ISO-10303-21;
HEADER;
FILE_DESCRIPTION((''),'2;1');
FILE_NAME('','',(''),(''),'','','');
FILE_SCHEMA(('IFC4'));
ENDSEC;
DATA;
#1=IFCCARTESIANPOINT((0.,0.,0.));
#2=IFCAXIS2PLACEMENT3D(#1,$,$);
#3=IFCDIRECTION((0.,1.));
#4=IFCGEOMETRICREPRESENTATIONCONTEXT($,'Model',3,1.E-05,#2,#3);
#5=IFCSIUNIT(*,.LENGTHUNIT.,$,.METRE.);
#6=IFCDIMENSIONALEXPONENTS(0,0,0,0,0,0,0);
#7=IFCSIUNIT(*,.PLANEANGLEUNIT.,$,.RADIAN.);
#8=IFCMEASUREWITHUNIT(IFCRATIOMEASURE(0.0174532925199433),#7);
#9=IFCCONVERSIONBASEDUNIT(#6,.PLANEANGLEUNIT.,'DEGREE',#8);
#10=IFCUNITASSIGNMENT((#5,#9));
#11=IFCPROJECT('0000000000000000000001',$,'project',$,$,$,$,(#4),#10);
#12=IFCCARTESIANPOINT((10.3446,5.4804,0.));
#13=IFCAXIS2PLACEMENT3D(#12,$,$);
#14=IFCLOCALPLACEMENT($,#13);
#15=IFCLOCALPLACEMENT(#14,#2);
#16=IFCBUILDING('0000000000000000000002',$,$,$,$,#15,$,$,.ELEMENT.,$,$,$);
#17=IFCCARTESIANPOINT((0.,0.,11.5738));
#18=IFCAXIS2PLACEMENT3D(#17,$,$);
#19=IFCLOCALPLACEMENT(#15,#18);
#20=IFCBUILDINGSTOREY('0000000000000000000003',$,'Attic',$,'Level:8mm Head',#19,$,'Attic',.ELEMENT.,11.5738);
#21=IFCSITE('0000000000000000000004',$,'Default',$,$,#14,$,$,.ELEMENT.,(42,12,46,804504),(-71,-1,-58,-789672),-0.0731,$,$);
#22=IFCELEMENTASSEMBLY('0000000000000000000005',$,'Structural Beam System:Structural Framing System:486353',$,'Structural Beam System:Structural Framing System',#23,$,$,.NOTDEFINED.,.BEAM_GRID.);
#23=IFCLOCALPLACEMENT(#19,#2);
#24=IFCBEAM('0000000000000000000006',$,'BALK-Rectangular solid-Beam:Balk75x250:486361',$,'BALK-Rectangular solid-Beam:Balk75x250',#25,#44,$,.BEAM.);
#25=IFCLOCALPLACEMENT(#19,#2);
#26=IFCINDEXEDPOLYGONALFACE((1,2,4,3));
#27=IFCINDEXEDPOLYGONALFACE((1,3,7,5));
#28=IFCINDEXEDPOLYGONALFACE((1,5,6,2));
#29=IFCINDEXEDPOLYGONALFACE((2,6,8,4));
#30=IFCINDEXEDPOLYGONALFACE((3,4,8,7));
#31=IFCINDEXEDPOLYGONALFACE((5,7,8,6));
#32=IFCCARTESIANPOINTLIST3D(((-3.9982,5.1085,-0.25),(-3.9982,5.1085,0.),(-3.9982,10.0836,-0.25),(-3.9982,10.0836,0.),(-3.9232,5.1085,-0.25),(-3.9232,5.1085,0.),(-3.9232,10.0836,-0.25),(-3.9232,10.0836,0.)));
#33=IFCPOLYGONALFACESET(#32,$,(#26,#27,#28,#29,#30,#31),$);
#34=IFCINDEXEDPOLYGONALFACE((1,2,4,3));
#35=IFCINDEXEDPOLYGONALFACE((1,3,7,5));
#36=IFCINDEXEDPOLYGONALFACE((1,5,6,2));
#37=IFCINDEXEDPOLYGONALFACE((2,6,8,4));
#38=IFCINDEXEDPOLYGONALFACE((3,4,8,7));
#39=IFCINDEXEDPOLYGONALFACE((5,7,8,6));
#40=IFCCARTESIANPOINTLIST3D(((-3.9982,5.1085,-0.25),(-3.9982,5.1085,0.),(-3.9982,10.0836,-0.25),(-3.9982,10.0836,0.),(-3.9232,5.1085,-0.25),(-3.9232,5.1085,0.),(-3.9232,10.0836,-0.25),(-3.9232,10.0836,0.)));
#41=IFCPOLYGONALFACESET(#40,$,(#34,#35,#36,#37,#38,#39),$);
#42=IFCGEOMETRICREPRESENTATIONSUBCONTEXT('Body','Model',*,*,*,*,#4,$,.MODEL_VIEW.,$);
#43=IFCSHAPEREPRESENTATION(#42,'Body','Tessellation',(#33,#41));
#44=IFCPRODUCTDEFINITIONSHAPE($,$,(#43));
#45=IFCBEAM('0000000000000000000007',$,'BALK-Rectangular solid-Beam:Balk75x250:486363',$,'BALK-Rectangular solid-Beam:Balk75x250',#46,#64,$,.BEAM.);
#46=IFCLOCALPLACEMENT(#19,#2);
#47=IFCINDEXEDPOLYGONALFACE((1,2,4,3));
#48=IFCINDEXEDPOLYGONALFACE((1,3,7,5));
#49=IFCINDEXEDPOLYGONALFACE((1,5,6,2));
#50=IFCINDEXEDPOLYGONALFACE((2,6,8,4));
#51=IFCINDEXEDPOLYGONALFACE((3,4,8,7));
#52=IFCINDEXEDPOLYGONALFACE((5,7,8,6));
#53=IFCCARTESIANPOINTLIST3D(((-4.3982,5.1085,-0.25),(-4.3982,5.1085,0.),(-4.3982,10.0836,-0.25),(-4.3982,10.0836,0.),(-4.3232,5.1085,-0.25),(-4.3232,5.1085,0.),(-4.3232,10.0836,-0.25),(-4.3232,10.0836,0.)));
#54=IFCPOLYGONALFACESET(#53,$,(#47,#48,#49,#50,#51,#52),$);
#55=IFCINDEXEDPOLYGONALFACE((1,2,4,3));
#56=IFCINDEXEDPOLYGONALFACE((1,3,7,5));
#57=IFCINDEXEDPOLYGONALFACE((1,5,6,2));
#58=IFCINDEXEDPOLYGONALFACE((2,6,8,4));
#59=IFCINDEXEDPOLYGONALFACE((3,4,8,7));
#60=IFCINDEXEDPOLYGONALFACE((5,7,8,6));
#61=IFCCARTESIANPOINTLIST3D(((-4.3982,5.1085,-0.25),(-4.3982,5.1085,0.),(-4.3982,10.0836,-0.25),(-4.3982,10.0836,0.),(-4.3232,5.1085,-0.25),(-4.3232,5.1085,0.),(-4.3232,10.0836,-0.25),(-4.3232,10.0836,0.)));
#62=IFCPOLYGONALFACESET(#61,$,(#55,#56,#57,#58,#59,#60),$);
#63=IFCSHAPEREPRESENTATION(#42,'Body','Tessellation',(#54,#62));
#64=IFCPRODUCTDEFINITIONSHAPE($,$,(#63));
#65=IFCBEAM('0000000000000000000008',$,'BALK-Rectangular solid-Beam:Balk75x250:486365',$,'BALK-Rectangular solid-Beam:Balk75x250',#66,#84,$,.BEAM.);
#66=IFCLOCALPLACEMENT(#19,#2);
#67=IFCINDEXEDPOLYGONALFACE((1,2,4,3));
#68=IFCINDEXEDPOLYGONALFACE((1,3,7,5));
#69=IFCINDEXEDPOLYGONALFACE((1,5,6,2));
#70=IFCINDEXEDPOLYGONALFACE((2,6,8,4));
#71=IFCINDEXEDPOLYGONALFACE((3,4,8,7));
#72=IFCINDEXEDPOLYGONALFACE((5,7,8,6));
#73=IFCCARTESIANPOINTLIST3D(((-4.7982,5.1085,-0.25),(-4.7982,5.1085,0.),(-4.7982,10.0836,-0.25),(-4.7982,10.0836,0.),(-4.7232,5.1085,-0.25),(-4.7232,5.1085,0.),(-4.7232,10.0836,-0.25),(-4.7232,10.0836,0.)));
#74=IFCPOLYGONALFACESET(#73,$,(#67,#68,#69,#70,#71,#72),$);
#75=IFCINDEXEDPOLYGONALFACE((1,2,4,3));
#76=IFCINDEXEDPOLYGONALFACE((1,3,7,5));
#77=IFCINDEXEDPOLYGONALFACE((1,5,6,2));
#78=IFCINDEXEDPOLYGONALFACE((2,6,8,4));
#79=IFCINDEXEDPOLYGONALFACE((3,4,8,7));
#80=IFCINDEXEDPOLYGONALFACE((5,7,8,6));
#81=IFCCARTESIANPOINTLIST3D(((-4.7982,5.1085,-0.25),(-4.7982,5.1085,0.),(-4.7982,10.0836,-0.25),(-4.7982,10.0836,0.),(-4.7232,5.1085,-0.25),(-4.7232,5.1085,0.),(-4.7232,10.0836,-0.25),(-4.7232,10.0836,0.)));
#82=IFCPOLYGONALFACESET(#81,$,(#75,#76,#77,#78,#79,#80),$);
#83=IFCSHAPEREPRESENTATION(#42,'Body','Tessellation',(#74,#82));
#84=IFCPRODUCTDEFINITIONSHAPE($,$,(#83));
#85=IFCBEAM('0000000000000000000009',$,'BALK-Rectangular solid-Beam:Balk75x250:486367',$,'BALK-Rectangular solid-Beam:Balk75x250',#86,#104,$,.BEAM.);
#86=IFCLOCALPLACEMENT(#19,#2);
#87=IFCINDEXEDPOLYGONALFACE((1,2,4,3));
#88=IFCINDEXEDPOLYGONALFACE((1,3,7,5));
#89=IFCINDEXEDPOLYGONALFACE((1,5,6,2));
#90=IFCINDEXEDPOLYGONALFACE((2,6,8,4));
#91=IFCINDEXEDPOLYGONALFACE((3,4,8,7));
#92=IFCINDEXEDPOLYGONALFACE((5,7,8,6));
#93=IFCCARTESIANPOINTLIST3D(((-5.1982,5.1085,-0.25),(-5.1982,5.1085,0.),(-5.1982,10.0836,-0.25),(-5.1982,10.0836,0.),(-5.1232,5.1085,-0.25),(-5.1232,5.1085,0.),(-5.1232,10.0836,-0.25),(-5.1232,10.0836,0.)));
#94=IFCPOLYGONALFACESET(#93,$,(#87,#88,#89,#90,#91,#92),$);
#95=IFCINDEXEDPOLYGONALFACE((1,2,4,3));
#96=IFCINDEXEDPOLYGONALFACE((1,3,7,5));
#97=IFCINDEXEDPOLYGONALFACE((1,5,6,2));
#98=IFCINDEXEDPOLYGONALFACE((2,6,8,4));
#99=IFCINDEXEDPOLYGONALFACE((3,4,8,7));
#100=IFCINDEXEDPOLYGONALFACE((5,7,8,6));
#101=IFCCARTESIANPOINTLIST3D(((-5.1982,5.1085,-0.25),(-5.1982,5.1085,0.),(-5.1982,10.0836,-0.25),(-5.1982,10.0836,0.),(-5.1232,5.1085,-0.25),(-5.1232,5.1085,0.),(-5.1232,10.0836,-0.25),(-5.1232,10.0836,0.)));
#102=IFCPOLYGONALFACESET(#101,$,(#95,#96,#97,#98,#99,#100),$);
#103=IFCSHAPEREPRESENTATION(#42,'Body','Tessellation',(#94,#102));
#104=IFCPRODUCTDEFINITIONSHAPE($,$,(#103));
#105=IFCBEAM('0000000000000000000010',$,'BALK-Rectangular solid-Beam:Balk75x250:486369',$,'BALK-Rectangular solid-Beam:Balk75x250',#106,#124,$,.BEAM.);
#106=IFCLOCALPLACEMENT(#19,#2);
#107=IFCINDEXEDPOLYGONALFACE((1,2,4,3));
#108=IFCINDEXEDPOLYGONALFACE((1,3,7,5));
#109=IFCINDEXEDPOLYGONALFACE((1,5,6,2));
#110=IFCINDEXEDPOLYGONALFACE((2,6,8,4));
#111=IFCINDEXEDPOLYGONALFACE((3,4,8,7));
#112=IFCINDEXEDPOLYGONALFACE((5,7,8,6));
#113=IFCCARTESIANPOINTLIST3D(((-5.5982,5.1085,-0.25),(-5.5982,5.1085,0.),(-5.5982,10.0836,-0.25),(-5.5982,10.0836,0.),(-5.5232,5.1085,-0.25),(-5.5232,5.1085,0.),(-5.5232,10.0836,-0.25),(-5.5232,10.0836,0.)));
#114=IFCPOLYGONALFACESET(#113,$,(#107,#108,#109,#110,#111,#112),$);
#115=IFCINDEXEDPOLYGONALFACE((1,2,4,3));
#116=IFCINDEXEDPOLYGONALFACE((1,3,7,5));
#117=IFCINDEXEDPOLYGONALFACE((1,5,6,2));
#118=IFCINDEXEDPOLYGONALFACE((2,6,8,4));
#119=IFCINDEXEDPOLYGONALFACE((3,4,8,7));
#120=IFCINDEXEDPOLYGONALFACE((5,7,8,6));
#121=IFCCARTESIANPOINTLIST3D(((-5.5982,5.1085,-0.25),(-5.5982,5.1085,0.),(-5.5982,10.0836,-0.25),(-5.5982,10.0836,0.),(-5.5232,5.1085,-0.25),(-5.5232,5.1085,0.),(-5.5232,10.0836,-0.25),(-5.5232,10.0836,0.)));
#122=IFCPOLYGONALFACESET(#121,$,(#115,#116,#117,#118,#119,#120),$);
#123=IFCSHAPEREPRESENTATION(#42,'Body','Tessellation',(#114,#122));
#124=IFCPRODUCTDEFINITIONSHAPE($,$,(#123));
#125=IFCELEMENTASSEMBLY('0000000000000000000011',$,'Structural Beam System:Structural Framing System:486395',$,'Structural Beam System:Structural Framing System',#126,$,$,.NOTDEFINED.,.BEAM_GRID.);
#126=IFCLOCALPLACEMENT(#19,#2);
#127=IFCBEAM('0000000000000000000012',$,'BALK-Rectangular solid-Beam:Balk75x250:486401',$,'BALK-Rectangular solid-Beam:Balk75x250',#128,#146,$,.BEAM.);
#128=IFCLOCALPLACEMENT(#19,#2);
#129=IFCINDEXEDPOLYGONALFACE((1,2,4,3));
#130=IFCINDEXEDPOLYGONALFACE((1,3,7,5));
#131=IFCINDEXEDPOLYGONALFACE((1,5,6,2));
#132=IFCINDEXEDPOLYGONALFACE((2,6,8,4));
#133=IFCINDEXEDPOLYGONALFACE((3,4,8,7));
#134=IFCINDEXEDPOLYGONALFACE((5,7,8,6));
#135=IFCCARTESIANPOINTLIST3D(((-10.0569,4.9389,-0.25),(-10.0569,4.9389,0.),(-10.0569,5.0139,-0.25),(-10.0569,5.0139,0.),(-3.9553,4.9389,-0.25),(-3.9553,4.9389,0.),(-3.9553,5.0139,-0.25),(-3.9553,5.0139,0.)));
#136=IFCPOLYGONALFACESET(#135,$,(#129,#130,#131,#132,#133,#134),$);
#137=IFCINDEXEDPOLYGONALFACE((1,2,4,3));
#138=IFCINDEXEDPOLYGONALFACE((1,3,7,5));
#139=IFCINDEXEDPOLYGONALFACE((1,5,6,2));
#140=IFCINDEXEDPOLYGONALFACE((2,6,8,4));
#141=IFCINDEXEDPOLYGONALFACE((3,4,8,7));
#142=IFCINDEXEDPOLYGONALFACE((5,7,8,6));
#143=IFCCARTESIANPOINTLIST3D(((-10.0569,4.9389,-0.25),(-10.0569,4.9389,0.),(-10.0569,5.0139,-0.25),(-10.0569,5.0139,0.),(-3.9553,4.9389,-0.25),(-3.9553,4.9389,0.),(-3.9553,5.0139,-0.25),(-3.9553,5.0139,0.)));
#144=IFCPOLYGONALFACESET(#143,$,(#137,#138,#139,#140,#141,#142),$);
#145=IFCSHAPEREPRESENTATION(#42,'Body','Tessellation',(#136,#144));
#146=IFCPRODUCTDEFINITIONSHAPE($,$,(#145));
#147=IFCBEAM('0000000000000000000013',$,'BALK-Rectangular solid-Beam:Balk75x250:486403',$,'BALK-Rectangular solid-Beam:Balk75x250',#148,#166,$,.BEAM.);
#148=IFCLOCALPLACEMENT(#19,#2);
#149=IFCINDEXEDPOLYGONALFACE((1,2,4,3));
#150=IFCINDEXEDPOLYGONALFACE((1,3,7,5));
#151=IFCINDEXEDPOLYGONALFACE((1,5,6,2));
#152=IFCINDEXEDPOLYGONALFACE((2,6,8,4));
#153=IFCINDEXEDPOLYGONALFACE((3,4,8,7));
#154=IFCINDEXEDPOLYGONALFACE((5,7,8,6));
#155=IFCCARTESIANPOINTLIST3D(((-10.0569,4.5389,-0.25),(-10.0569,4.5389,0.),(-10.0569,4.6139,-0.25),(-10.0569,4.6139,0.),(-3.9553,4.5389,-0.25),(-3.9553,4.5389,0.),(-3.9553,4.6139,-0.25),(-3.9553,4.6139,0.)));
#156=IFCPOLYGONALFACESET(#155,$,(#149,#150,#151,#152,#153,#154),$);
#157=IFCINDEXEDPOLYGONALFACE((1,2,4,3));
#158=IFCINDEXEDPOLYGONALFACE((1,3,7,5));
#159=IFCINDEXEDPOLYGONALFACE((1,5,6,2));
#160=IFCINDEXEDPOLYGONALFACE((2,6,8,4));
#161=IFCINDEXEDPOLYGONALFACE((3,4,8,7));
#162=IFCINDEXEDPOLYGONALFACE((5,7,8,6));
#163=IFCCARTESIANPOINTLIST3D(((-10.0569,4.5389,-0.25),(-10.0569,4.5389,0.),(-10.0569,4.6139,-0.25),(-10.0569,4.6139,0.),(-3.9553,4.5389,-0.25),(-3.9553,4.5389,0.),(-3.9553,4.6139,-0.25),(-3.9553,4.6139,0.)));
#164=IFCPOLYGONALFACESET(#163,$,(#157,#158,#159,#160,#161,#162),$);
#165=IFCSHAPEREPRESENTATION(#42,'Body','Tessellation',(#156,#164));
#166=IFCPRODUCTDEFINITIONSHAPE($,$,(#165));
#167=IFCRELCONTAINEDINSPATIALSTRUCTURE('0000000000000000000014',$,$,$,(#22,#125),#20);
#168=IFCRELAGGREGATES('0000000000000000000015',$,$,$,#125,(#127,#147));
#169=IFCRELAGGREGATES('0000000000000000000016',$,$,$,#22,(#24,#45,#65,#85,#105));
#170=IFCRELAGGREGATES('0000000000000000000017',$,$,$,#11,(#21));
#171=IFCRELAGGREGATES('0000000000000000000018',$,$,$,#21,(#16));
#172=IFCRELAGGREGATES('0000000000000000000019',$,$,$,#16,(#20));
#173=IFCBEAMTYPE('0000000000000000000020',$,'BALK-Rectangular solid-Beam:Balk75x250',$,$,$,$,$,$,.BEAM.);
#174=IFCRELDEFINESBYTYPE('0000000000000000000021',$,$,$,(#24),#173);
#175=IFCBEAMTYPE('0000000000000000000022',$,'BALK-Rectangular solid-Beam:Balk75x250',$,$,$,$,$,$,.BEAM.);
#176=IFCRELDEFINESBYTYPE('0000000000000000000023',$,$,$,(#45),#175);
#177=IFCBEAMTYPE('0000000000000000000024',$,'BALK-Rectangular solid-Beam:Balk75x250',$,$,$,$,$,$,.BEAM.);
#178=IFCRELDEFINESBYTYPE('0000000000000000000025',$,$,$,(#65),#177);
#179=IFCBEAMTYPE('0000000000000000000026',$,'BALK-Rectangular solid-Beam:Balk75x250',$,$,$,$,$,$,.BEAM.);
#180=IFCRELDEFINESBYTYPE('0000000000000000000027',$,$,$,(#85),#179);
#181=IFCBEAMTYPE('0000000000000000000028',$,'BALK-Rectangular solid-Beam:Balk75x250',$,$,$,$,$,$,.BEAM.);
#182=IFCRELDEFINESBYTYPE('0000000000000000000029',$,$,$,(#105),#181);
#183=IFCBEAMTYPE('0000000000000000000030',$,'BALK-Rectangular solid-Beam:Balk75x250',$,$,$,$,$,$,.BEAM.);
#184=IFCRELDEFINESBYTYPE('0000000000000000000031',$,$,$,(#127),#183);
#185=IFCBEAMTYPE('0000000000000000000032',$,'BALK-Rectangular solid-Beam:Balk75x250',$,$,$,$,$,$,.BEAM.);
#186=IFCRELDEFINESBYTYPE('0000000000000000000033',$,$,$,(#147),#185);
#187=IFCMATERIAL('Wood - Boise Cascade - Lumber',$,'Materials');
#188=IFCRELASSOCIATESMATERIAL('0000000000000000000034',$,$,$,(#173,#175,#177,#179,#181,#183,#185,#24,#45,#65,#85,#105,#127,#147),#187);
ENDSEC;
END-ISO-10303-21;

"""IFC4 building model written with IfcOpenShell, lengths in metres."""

from ifc_helpers import new_model, entity, si_unit, converted_unit, direction, frame, frame_2d, origin, place, context, subcontext, project, spatial, rectangle, extrude, source, transform, mapped, material, material_profile, profile_set, profile_usage, type_object, type_shapes, element, aggregate, save


model = new_model("IFC4")

# Units and contexts
model_context = context("Model", 3, precision=1e-05, world=origin(), true_north=direction((0.0, 1.0)))
body_context = subcontext(model_context, "Body", "Model", "MODEL_VIEW")
ifc_project = project(units=[si_unit("LENGTHUNIT", "METRE"), converted_unit("PLANEANGLEUNIT", "DEGREE", entity("IfcRatioMeasure", 0.0174532925199433), si_unit("PLANEANGLEUNIT", "RADIAN"), dimensions=[0, 0, 0, 0, 0, 0, 0])], contexts=[model_context])

# Site, building, storey
site_placement = place(None, frame((10.3446, 5.4804, 0.0)))
site = spatial("IfcSite", under=ifc_project, at=site_placement, Name="Default", CompositionType="ELEMENT", RefLatitude=(42, 12, 46, 804504), RefLongitude=(-71, -1, -58, -789672), RefElevation=-0.0731)
building_placement = place(site_placement, origin())
building = spatial("IfcBuilding", under=site, at=building_placement, CompositionType="ELEMENT")
storey_placement = place(building_placement, frame((0.0, 0.0, 11.5738)))
storey = spatial("IfcBuildingStorey", under=building, at=storey_placement, Name="Attic", ObjectType="Level:8mm Head", LongName="Attic", CompositionType="ELEMENT", Elevation=11.5738)

# Element assemblies, beams
assembly_1_placement = place(storey_placement, origin())
assembly_1 = element("IfcElementAssembly", 1, at=assembly_1_placement, inside=storey, Name="Structural Beam System:Structural Framing System:486353", ObjectType="Structural Beam System:Structural Framing System", AssemblyPlace="NOTDEFINED", PredefinedType="BEAM_GRID")
ifc_material = material(Name="Wood - Boise Cascade - Lumber", Category="Materials")
ifc_material_profile = material_profile(ifc_material, rectangle(XDim=0.25, YDim=0.075, at=frame_2d((0.0, 0.0), x_axis=(1.0, 0.0))), Name="Balk75x250")
ifc_profile_set = profile_set([ifc_material_profile], Name="Balk75x250")
ifc_profile_usage_1 = profile_usage(ifc_profile_set, cardinal=8)
beam_type_1 = type_object("IfcBeamType", Name="BALK-Rectangular solid-Beam:Balk75x250", PredefinedType="BEAM", material=ifc_profile_set)
shared_shape_1 = source(origin(), body_context, "Body", "SweptSolid", [
    extrude(rectangle(XDim=0.25, YDim=0.075, at=frame_2d((0.0, 0.0), x_axis=(0.0, 1.0))), frame((-3.9607, 10.0836, 11.4488), z_axis=(0.0, -1.0, 0.0), x_axis=(-1.0, 0.0, 0.0)), (0.0, 0.0, 1.0), 4.9751),
    extrude(rectangle(XDim=0.25, YDim=0.075, at=frame_2d((0.0, 0.0), x_axis=(0.0, 1.0))), frame((-3.9607, 10.0836, 11.4488), z_axis=(0.0, -1.0, 0.0), x_axis=(-1.0, 0.0, 0.0)), (0.0, 0.0, 1.0), 4.9751),
])
type_shapes(beam_type_1, [shared_shape_1])
beam_1_placement = place(assembly_1_placement, frame((0.0, 0.0, -11.5738)))
beam_1 = element("IfcBeam", 2, at=beam_1_placement, type_object=beam_type_1, material=ifc_profile_usage_1, Name="BALK-Rectangular solid-Beam:Balk75x250:486361", ObjectType="BALK-Rectangular solid-Beam:Balk75x250", PredefinedType="BEAM", context=body_context, shape_type="MappedRepresentation", body=[
    mapped(shared_shape_1, transform((0.0, 0.0, 0.0), scale=1.0)),
])
ifc_profile_usage_2 = profile_usage(ifc_profile_set, cardinal=8)
beam_type_2 = type_object("IfcBeamType", Name="BALK-Rectangular solid-Beam:Balk75x250", PredefinedType="BEAM", material=ifc_profile_set)
shared_shape_2 = source(origin(), body_context, "Body", "SweptSolid", [
    extrude(rectangle(XDim=0.25, YDim=0.075, at=frame_2d((0.0, 0.0), x_axis=(0.0, 1.0))), frame((-4.3607, 10.0836, 11.4488), z_axis=(0.0, -1.0, 0.0), x_axis=(-1.0, 0.0, 0.0)), (0.0, 0.0, 1.0), 4.9751),
    extrude(rectangle(XDim=0.25, YDim=0.075, at=frame_2d((0.0, 0.0), x_axis=(0.0, 1.0))), frame((-4.3607, 10.0836, 11.4488), z_axis=(0.0, -1.0, 0.0), x_axis=(-1.0, 0.0, 0.0)), (0.0, 0.0, 1.0), 4.9751),
])
type_shapes(beam_type_2, [shared_shape_2])
beam_2_placement = place(assembly_1_placement, frame((0.0, 0.0, -11.5738)))
beam_2 = element("IfcBeam", 3, at=beam_2_placement, type_object=beam_type_2, material=ifc_profile_usage_2, Name="BALK-Rectangular solid-Beam:Balk75x250:486363", ObjectType="BALK-Rectangular solid-Beam:Balk75x250", PredefinedType="BEAM", context=body_context, shape_type="MappedRepresentation", body=[
    mapped(shared_shape_2, transform((0.0, 0.0, 0.0), scale=1.0)),
])
ifc_profile_usage_3 = profile_usage(ifc_profile_set, cardinal=8)
beam_type_3 = type_object("IfcBeamType", Name="BALK-Rectangular solid-Beam:Balk75x250", PredefinedType="BEAM", material=ifc_profile_set)
shared_shape_3 = source(origin(), body_context, "Body", "SweptSolid", [
    extrude(rectangle(XDim=0.25, YDim=0.075, at=frame_2d((0.0, 0.0), x_axis=(0.0, 1.0))), frame((-4.7607, 10.0836, 11.4488), z_axis=(0.0, -1.0, 0.0), x_axis=(-1.0, 0.0, 0.0)), (0.0, 0.0, 1.0), 4.9751),
    extrude(rectangle(XDim=0.25, YDim=0.075, at=frame_2d((0.0, 0.0), x_axis=(0.0, 1.0))), frame((-4.7607, 10.0836, 11.4488), z_axis=(0.0, -1.0, 0.0), x_axis=(-1.0, 0.0, 0.0)), (0.0, 0.0, 1.0), 4.9751),
])
type_shapes(beam_type_3, [shared_shape_3])
beam_3_placement = place(assembly_1_placement, frame((0.0, 0.0, -11.5738)))
beam_3 = element("IfcBeam", 4, at=beam_3_placement, type_object=beam_type_3, material=ifc_profile_usage_3, Name="BALK-Rectangular solid-Beam:Balk75x250:486365", ObjectType="BALK-Rectangular solid-Beam:Balk75x250", PredefinedType="BEAM", context=body_context, shape_type="MappedRepresentation", body=[
    mapped(shared_shape_3, transform((0.0, 0.0, 0.0), scale=1.0)),
])
ifc_profile_usage_4 = profile_usage(ifc_profile_set, cardinal=8)
beam_type_4 = type_object("IfcBeamType", Name="BALK-Rectangular solid-Beam:Balk75x250", PredefinedType="BEAM", material=ifc_profile_set)
shared_shape_4 = source(origin(), body_context, "Body", "SweptSolid", [
    extrude(rectangle(XDim=0.25, YDim=0.075, at=frame_2d((0.0, 0.0), x_axis=(0.0, 1.0))), frame((-5.1607, 10.0836, 11.4488), z_axis=(0.0, -1.0, 0.0), x_axis=(-1.0, 0.0, 0.0)), (0.0, 0.0, 1.0), 4.9751),
    extrude(rectangle(XDim=0.25, YDim=0.075, at=frame_2d((0.0, 0.0), x_axis=(0.0, 1.0))), frame((-5.1607, 10.0836, 11.4488), z_axis=(0.0, -1.0, 0.0), x_axis=(-1.0, 0.0, 0.0)), (0.0, 0.0, 1.0), 4.9751),
])
type_shapes(beam_type_4, [shared_shape_4])
beam_4_placement = place(assembly_1_placement, frame((0.0, 0.0, -11.5738)))
beam_4 = element("IfcBeam", 5, at=beam_4_placement, type_object=beam_type_4, material=ifc_profile_usage_4, Name="BALK-Rectangular solid-Beam:Balk75x250:486367", ObjectType="BALK-Rectangular solid-Beam:Balk75x250", PredefinedType="BEAM", context=body_context, shape_type="MappedRepresentation", body=[
    mapped(shared_shape_4, transform((0.0, 0.0, 0.0), scale=1.0)),
])
ifc_profile_usage_5 = profile_usage(ifc_profile_set, cardinal=8)
beam_type_5 = type_object("IfcBeamType", Name="BALK-Rectangular solid-Beam:Balk75x250", PredefinedType="BEAM", material=ifc_profile_set)
shared_shape_5 = source(origin(), body_context, "Body", "SweptSolid", [
    extrude(rectangle(XDim=0.25, YDim=0.075, at=frame_2d((0.0, 0.0), x_axis=(0.0, 1.0))), frame((-5.5607, 10.0836, 11.4488), z_axis=(0.0, -1.0, 0.0), x_axis=(-1.0, 0.0, 0.0)), (0.0, 0.0, 1.0), 4.9751),
    extrude(rectangle(XDim=0.25, YDim=0.075, at=frame_2d((0.0, 0.0), x_axis=(0.0, 1.0))), frame((-5.5607, 10.0836, 11.4488), z_axis=(0.0, -1.0, 0.0), x_axis=(-1.0, 0.0, 0.0)), (0.0, 0.0, 1.0), 4.9751),
])
type_shapes(beam_type_5, [shared_shape_5])
beam_5_placement = place(assembly_1_placement, frame((0.0, 0.0, -11.5738)))
beam_5 = element("IfcBeam", 6, at=beam_5_placement, type_object=beam_type_5, material=ifc_profile_usage_5, Name="BALK-Rectangular solid-Beam:Balk75x250:486369", ObjectType="BALK-Rectangular solid-Beam:Balk75x250", PredefinedType="BEAM", context=body_context, shape_type="MappedRepresentation", body=[
    mapped(shared_shape_5, transform((0.0, 0.0, 0.0), scale=1.0)),
])
assembly_2_placement = place(storey_placement, origin())
assembly_2 = element("IfcElementAssembly", 7, at=assembly_2_placement, inside=storey, Name="Structural Beam System:Structural Framing System:486395", ObjectType="Structural Beam System:Structural Framing System", AssemblyPlace="NOTDEFINED", PredefinedType="BEAM_GRID")
ifc_profile_usage_6 = profile_usage(ifc_profile_set, cardinal=8)
beam_type_6 = type_object("IfcBeamType", Name="BALK-Rectangular solid-Beam:Balk75x250", PredefinedType="BEAM", material=ifc_profile_set)
shared_shape_6 = source(origin(), body_context, "Body", "SweptSolid", [
    extrude(rectangle(XDim=0.25, YDim=0.075, at=frame_2d((0.0, 0.0), x_axis=(1.0, 0.0))), frame((-10.0569, 4.9764, 11.4488), z_axis=(1.0, 0.0, 0.0), x_axis=(0.0, 0.0, -1.0)), (0.0, 0.0, 1.0), 6.1016),
    extrude(rectangle(XDim=0.25, YDim=0.075, at=frame_2d((0.0, 0.0), x_axis=(1.0, 0.0))), frame((-10.0569, 4.9764, 11.4488), z_axis=(1.0, 0.0, 0.0), x_axis=(0.0, 0.0, -1.0)), (0.0, 0.0, 1.0), 6.1016),
])
type_shapes(beam_type_6, [shared_shape_6])
beam_6_placement = place(assembly_2_placement, frame((0.0, 0.0, -11.5738)))
beam_6 = element("IfcBeam", 8, at=beam_6_placement, type_object=beam_type_6, material=ifc_profile_usage_6, Name="BALK-Rectangular solid-Beam:Balk75x250:486401", ObjectType="BALK-Rectangular solid-Beam:Balk75x250", PredefinedType="BEAM", context=body_context, shape_type="MappedRepresentation", body=[
    mapped(shared_shape_6, transform((0.0, 0.0, 0.0), scale=1.0)),
])
ifc_profile_usage_7 = profile_usage(ifc_profile_set, cardinal=8)
beam_type_7 = type_object("IfcBeamType", Name="BALK-Rectangular solid-Beam:Balk75x250", PredefinedType="BEAM", material=ifc_profile_set)
shared_shape_7 = source(origin(), body_context, "Body", "SweptSolid", [
    extrude(rectangle(XDim=0.25, YDim=0.075, at=frame_2d((0.0, 0.0), x_axis=(1.0, 0.0))), frame((-10.0569, 4.5764, 11.4488), z_axis=(1.0, 0.0, 0.0), x_axis=(0.0, 0.0, -1.0)), (0.0, 0.0, 1.0), 6.1016),
    extrude(rectangle(XDim=0.25, YDim=0.075, at=frame_2d((0.0, 0.0), x_axis=(1.0, 0.0))), frame((-10.0569, 4.5764, 11.4488), z_axis=(1.0, 0.0, 0.0), x_axis=(0.0, 0.0, -1.0)), (0.0, 0.0, 1.0), 6.1016),
])
type_shapes(beam_type_7, [shared_shape_7])
beam_7_placement = place(assembly_2_placement, frame((0.0, 0.0, -11.5738)))
beam_7 = element("IfcBeam", 9, at=beam_7_placement, type_object=beam_type_7, material=ifc_profile_usage_7, Name="BALK-Rectangular solid-Beam:Balk75x250:486403", ObjectType="BALK-Rectangular solid-Beam:Balk75x250", PredefinedType="BEAM", context=body_context, shape_type="MappedRepresentation", body=[
    mapped(shared_shape_7, transform((0.0, 0.0, 0.0), scale=1.0)),
])
aggregate(assembly_2, [beam_6, beam_7])

aggregate(assembly_1, [beam_1, beam_2, beam_3, beam_4, beam_5])

save(model, "model.ifc")
